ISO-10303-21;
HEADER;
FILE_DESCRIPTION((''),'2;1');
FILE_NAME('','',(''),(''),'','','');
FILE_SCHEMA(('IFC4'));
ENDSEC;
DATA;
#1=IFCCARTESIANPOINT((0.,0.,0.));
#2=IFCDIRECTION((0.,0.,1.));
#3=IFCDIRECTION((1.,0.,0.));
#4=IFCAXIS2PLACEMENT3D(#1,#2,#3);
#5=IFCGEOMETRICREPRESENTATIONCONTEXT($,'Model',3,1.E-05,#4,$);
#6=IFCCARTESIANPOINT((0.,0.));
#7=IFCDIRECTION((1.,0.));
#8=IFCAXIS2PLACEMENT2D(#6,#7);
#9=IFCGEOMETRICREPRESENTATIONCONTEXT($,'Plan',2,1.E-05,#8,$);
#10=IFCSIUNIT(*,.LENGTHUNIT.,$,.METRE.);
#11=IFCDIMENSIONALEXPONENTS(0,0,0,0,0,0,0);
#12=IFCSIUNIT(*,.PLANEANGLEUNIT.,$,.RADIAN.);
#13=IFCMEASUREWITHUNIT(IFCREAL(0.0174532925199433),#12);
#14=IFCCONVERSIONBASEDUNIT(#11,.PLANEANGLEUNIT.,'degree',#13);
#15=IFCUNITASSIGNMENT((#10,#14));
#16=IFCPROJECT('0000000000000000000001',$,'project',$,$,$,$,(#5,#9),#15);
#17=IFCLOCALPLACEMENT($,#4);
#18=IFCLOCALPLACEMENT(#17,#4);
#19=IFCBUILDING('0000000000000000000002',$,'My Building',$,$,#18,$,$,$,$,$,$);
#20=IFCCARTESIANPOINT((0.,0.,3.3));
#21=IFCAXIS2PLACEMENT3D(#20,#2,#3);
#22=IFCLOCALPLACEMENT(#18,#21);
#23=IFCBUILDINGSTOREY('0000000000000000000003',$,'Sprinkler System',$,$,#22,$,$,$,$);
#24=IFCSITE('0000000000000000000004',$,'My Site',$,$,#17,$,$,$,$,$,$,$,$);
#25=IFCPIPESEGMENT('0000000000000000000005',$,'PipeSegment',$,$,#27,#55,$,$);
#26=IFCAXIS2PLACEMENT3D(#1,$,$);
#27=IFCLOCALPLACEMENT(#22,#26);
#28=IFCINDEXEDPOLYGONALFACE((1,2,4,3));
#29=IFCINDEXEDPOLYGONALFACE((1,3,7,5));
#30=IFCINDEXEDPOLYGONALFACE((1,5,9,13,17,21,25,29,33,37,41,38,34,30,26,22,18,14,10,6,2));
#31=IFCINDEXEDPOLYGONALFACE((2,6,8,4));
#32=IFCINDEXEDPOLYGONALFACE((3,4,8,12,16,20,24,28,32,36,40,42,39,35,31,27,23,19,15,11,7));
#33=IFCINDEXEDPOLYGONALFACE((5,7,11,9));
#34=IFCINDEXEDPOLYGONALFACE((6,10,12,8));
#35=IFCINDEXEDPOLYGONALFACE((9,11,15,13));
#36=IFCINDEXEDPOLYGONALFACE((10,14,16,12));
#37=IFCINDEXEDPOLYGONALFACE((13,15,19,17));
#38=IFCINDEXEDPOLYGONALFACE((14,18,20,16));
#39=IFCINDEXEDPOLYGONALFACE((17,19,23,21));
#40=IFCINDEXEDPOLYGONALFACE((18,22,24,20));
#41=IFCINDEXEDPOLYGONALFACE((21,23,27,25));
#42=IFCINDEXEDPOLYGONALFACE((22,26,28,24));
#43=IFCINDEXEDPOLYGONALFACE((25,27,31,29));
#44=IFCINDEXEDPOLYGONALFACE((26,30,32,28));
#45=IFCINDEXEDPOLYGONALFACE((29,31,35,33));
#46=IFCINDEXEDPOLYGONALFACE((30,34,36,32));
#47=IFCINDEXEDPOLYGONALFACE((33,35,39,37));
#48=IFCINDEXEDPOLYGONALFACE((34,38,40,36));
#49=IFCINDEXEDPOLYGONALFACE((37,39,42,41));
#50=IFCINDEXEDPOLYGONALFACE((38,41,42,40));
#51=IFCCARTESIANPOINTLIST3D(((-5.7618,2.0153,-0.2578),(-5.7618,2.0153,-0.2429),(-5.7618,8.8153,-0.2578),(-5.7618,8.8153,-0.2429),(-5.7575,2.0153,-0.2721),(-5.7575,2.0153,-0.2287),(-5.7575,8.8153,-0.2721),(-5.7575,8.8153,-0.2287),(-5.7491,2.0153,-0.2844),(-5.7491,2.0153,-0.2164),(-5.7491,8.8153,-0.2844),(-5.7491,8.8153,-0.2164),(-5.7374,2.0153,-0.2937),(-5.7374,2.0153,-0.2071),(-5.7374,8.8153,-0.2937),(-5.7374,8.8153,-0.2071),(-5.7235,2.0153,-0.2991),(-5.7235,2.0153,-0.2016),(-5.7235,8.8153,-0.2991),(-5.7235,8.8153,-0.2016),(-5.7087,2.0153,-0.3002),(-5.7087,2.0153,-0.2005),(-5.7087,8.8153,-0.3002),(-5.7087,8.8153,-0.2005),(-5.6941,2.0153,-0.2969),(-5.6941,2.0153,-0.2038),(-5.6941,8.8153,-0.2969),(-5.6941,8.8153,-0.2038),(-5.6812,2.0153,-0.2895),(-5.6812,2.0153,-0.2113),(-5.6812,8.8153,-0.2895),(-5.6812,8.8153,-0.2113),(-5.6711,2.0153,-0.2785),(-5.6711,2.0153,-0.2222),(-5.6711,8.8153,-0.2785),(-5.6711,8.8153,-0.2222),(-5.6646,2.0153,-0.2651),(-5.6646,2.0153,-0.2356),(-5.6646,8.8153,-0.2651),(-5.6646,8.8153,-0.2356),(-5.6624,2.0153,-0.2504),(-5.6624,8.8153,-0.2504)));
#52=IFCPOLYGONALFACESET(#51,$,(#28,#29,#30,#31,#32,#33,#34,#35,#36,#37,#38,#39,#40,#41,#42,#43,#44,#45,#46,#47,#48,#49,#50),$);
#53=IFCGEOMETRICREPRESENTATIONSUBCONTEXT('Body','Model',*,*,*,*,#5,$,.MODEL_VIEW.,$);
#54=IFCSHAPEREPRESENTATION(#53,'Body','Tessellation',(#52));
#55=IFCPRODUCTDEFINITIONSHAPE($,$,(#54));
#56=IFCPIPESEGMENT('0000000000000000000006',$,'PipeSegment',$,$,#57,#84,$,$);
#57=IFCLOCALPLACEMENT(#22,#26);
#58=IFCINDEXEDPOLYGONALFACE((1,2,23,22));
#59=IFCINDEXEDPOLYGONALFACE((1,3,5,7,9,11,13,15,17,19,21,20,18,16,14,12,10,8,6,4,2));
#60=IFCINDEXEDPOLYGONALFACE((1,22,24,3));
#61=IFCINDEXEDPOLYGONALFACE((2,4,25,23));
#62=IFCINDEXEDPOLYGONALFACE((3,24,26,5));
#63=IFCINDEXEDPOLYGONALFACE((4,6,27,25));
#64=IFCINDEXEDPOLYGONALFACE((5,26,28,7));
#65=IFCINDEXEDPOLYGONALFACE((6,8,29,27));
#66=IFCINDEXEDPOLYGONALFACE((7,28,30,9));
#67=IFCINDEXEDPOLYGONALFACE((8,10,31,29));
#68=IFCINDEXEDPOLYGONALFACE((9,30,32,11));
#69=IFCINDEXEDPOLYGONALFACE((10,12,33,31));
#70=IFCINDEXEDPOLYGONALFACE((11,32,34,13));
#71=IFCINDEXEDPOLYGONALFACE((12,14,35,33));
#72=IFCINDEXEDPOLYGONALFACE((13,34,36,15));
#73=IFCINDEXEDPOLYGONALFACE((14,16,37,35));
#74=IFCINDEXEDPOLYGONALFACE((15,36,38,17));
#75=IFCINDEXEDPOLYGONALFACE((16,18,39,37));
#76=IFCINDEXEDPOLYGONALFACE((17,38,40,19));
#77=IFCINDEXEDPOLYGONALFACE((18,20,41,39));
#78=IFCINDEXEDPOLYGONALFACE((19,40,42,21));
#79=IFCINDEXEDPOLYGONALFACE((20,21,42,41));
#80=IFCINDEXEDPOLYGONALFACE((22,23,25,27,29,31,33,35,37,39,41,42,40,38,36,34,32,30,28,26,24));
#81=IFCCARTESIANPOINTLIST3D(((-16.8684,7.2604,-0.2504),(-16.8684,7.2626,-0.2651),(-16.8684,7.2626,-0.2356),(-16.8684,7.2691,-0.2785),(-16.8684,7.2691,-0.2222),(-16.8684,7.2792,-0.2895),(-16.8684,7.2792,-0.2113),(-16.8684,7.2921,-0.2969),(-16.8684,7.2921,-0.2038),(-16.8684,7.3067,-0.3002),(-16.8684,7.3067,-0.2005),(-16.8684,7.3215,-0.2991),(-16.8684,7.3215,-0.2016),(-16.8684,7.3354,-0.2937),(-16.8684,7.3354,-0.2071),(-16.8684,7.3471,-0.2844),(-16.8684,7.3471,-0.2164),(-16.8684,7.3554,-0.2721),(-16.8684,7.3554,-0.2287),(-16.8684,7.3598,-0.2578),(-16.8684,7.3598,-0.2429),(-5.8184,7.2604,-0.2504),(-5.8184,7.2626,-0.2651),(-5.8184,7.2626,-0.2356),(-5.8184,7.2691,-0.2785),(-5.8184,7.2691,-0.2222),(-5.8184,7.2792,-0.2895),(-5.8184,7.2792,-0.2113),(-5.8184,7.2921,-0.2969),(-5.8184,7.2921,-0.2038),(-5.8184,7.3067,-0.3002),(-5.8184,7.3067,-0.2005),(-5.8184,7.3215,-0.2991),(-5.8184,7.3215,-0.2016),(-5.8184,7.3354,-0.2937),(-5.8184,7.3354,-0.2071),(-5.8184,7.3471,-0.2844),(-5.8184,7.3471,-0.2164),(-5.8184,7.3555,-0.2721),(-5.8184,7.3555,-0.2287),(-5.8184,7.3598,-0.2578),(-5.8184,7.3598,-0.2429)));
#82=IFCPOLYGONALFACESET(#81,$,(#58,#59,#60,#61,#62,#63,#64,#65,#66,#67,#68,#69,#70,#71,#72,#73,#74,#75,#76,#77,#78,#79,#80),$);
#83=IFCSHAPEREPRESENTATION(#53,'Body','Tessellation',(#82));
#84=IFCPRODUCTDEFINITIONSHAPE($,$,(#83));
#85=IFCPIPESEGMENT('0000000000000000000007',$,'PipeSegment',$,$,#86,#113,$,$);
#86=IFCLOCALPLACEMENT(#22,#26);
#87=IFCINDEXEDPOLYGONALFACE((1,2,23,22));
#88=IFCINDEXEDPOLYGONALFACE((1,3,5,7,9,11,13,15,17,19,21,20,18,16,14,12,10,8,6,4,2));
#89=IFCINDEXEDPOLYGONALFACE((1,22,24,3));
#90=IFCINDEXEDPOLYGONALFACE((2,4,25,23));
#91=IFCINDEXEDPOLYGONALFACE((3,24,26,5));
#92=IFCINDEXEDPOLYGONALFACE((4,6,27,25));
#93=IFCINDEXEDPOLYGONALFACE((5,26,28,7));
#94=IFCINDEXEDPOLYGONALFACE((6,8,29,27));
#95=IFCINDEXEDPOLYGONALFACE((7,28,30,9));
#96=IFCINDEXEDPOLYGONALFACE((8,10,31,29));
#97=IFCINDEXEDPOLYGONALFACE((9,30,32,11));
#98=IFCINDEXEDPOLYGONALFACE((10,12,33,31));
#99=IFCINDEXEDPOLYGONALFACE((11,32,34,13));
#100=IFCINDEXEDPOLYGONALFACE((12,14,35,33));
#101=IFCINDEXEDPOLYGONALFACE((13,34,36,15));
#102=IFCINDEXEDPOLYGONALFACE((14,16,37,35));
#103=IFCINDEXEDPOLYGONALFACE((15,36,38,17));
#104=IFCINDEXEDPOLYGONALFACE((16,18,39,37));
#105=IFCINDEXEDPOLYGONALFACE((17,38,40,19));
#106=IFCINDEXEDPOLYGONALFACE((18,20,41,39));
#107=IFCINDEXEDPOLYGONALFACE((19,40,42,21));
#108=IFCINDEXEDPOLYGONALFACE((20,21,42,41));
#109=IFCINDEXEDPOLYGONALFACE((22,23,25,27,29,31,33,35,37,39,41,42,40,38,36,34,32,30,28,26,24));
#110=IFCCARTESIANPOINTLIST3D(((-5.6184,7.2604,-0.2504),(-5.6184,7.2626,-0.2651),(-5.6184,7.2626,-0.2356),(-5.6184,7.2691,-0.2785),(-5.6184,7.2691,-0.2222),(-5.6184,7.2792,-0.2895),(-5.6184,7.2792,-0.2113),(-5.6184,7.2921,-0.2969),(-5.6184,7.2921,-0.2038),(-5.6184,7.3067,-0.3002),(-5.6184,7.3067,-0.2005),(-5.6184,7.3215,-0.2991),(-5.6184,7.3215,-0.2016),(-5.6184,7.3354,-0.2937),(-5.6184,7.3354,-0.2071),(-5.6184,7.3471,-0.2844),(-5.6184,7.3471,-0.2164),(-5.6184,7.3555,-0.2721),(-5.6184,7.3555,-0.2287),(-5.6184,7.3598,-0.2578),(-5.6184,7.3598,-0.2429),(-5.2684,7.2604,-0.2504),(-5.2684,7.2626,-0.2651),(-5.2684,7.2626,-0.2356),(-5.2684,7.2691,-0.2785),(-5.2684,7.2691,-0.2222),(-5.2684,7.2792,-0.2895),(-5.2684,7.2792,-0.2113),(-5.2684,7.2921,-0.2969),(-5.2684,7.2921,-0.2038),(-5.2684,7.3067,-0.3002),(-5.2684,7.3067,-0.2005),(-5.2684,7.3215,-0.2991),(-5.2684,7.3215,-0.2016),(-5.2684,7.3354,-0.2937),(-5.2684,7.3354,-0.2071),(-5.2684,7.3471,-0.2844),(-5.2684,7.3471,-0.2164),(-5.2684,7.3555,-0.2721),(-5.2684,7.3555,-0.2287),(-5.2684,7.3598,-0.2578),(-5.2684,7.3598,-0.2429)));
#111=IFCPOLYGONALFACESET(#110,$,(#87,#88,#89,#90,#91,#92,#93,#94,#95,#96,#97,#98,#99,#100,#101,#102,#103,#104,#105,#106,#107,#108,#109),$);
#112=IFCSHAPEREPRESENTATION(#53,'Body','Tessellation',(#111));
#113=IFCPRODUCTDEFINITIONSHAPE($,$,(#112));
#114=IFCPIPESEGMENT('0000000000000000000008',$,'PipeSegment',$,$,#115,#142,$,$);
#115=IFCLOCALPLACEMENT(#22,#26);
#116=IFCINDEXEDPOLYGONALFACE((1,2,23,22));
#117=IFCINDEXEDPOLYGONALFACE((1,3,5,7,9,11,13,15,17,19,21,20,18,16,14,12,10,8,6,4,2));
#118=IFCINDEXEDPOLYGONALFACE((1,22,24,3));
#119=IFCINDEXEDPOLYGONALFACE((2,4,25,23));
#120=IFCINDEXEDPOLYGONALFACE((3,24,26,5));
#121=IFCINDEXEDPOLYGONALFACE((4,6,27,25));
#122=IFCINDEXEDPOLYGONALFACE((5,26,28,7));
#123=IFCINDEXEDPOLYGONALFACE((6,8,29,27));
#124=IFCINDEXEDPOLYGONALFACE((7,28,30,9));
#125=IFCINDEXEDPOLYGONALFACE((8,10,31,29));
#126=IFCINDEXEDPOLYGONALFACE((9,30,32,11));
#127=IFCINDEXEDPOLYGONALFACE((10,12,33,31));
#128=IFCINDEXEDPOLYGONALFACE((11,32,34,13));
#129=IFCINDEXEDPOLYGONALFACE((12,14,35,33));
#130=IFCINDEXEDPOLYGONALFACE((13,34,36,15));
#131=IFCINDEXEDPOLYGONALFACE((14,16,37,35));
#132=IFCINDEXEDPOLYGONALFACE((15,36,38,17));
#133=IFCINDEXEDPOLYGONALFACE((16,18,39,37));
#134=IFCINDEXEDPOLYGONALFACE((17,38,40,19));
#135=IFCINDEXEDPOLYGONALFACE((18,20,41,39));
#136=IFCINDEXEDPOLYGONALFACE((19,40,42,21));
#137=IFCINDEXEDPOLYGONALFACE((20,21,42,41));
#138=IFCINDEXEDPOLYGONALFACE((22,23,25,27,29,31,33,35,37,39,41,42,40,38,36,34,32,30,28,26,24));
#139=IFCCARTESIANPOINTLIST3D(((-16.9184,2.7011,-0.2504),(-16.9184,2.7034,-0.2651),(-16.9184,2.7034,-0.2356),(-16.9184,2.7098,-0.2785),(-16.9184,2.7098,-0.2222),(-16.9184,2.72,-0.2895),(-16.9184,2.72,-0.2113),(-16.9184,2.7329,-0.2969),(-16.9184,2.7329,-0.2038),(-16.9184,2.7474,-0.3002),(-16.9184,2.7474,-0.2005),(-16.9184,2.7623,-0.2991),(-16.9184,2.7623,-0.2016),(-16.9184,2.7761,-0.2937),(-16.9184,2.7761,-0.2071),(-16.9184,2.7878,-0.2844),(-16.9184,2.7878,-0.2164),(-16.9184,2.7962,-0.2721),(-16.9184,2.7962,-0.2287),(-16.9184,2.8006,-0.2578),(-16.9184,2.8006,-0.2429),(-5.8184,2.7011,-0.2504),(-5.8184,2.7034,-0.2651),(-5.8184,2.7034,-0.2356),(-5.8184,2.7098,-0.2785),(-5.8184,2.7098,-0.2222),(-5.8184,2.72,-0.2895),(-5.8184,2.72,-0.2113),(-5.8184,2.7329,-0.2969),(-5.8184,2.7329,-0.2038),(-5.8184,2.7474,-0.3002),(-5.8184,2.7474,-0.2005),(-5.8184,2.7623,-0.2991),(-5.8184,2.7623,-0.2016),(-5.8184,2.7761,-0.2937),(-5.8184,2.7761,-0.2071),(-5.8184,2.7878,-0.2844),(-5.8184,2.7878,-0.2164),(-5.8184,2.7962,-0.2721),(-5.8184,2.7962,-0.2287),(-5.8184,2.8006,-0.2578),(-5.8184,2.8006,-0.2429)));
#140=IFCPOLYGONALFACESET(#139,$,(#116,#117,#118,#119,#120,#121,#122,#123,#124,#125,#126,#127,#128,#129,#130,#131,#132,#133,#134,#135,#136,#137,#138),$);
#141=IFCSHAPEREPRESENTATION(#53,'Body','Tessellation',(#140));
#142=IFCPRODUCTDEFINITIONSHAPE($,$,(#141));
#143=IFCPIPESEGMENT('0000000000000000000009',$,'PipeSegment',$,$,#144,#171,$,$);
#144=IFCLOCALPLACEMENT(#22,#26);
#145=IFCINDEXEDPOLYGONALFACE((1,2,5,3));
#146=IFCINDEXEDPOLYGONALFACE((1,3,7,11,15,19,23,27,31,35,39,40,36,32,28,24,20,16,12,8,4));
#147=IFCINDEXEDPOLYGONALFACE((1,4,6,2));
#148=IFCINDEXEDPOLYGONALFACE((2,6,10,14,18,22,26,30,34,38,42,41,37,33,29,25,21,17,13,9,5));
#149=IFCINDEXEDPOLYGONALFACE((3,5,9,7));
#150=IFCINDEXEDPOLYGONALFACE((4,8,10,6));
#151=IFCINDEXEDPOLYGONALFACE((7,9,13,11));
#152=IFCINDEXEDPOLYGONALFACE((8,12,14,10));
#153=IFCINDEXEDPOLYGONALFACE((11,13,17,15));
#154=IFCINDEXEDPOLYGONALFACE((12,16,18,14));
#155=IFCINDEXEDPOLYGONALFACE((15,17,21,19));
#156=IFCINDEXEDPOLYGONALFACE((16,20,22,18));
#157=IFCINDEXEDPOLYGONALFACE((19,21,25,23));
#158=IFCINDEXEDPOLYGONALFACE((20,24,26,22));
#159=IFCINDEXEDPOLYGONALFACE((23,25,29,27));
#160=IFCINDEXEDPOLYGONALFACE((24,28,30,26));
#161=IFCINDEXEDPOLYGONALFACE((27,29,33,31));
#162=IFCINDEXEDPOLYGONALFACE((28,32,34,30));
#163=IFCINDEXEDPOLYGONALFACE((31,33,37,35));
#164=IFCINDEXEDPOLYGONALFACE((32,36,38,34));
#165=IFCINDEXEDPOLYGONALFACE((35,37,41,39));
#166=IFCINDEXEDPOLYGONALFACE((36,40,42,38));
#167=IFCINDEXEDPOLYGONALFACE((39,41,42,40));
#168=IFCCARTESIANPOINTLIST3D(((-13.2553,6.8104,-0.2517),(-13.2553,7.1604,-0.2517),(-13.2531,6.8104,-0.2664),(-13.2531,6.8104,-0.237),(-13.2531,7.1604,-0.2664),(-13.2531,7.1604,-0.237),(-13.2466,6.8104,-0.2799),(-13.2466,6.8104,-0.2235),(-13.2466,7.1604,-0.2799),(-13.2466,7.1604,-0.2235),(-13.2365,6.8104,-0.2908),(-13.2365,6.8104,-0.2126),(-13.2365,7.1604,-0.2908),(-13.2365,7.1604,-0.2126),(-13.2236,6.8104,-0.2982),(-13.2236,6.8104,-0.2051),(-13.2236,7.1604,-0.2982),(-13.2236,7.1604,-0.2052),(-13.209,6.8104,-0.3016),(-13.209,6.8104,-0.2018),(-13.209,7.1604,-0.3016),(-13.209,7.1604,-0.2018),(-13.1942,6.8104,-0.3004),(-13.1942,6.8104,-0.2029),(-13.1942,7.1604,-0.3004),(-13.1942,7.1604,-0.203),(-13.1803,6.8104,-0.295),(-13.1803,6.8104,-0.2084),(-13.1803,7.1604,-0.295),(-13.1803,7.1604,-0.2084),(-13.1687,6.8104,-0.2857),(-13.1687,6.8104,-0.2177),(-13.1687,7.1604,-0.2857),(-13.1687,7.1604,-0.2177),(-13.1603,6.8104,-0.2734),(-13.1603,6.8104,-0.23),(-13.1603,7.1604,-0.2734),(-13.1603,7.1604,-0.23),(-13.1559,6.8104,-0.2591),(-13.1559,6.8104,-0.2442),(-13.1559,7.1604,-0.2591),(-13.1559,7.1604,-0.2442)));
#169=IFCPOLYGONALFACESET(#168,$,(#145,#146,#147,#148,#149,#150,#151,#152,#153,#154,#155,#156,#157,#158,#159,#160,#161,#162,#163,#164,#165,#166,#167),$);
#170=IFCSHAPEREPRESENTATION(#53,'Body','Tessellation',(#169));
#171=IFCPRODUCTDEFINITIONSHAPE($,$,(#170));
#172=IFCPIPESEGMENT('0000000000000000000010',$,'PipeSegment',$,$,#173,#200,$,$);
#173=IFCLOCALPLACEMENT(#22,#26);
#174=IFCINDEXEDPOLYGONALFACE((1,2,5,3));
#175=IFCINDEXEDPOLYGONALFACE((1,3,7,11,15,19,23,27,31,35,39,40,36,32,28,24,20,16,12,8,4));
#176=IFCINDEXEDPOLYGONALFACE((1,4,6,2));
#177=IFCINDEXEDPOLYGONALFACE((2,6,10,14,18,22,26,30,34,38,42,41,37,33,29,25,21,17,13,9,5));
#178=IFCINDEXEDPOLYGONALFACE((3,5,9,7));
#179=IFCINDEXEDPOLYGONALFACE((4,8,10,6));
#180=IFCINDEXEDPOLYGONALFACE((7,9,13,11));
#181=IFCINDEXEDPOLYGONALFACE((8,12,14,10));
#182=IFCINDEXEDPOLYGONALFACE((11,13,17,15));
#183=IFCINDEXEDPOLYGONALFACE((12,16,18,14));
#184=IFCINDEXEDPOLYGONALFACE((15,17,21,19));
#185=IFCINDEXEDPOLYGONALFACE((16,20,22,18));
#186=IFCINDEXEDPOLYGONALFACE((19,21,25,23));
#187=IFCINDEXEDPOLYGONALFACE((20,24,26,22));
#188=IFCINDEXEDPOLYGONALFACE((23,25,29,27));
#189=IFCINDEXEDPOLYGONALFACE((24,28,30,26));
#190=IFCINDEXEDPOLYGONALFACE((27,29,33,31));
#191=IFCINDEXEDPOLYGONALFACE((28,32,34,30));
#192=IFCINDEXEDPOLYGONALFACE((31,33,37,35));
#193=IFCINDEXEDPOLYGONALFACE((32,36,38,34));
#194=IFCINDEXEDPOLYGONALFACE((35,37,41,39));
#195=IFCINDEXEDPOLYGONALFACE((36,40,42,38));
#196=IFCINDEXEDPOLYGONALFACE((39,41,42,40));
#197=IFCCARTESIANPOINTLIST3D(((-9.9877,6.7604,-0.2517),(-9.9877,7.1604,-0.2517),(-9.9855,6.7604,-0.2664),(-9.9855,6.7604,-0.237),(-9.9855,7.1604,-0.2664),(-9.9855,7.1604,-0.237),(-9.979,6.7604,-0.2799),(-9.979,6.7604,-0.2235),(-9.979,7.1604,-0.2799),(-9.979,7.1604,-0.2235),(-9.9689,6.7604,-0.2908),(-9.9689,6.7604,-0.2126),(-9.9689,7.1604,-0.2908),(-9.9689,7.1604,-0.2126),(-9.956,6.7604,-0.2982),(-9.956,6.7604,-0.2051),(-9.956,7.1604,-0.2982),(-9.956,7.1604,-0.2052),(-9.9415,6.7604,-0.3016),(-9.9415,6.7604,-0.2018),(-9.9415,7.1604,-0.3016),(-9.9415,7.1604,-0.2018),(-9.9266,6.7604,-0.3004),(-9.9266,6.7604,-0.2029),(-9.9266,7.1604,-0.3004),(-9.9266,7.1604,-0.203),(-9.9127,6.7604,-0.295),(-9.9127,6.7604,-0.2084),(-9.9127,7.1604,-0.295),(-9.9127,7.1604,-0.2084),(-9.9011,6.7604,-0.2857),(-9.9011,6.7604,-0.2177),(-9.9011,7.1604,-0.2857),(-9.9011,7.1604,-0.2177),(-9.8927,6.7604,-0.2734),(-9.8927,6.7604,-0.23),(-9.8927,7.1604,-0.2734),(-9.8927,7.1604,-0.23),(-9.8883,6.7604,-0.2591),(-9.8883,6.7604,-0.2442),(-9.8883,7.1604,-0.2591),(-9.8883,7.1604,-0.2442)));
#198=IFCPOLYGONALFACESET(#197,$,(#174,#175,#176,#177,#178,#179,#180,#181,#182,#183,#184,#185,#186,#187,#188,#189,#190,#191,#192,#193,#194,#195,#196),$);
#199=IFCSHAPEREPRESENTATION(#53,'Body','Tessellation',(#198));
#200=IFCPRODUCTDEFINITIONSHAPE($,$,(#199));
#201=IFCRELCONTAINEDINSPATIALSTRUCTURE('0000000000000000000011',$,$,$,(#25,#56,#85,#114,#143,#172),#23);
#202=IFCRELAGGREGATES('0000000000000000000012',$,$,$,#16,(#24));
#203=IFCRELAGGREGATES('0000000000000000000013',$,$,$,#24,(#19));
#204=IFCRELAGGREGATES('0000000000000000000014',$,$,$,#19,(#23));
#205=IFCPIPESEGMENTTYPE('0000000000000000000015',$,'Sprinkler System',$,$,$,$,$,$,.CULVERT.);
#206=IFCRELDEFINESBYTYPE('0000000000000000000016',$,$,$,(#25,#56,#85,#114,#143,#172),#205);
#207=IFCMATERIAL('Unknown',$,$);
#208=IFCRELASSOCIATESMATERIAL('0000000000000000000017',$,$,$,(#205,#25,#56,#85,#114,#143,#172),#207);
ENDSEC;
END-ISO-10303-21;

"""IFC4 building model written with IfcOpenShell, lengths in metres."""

from ifc_helpers import new_model, entity, si_unit, converted_unit, frame, origin_with_axes, origin_2d_with_axis, place, context, subcontext, project, spatial, circle, extrude, material, material_profile, profile_set, profile_usage, type_object, element, save


model = new_model("IFC4")

# Units and contexts
model_context = context("Model", 3, precision=1e-05, world=origin_with_axes())
plan_context = context("Plan", 2, precision=1e-05, world=origin_2d_with_axis())
body_context = subcontext(model_context, "Body", "Model", "MODEL_VIEW")
ifc_project = project(units=[si_unit("LENGTHUNIT", "METRE"), converted_unit("PLANEANGLEUNIT", "degree", entity("IfcReal", 0.0174532925199433), si_unit("PLANEANGLEUNIT", "RADIAN"), dimensions=[0, 0, 0, 0, 0, 0, 0])], contexts=[model_context, plan_context])

# Site, building, storey
site_placement = place(None, origin_with_axes())
site = spatial("IfcSite", under=ifc_project, at=site_placement, Name="My Site")
building_placement = place(site_placement, origin_with_axes())
building = spatial("IfcBuilding", under=site, at=building_placement, Name="My Building")
storey_placement = place(building_placement, frame((0.0, 0.0, 3.3), z_axis=(0.0, 0.0, 1.0), x_axis=(1.0, 0.0, 0.0)))
storey = spatial("IfcBuildingStorey", under=building, at=storey_placement, Name="Sprinkler System")

# Pipe segments
ifc_material = material(Name="Unknown")
ifc_material_profile_1 = material_profile(ifc_material, circle(Radius=0.05))
ifc_profile_set_1 = profile_set([ifc_material_profile_1])
ifc_profile_usage_1 = profile_usage(ifc_profile_set_1, cardinal=5)
pipe_segment_type = type_object("IfcPipeSegmentType", Name="Sprinkler System", PredefinedType="CULVERT", material=ifc_profile_set_1)
pipe_segment_1_placement = place(storey_placement, frame((-5.7124, 8.8153, -0.2504), z_axis=(0.0, -1.0, 0.0), x_axis=(1.0, 0.0, 0.0)))
element("IfcPipeSegment", 1, at=pipe_segment_1_placement, inside=storey, type_object=pipe_segment_type, material=ifc_profile_usage_1, Name="PipeSegment", context=body_context, shape_type="SweptSolid", body=[
    extrude(circle(Radius=0.05), origin_with_axes(), (0.0, 0.0, 1.0), 6.8),
])
ifc_profile_usage_2 = profile_usage(ifc_profile_set_1, cardinal=5)
pipe_segment_2_placement = place(storey_placement, frame((-5.8184, 7.3104, -0.2504), z_axis=(-1.0, 0.0, 0.0), x_axis=(0.0, -1.0, 0.0)))
element("IfcPipeSegment", 2, at=pipe_segment_2_placement, inside=storey, type_object=pipe_segment_type, material=ifc_profile_usage_2, Name="PipeSegment", context=body_context, shape_type="SweptSolid", body=[
    extrude(circle(Radius=0.05), origin_with_axes(), (0.0, 0.0, 1.0), 11.05),
])
ifc_profile_usage_3 = profile_usage(ifc_profile_set_1, cardinal=5)
pipe_segment_3_placement = place(storey_placement, frame((-5.2684, 7.3104, -0.2504), z_axis=(-1.0, 0.0, 0.0), x_axis=(0.0, -1.0, 0.0)))
element("IfcPipeSegment", 3, at=pipe_segment_3_placement, inside=storey, type_object=pipe_segment_type, material=ifc_profile_usage_3, Name="PipeSegment", context=body_context, shape_type="SweptSolid", body=[
    extrude(circle(Radius=0.05), origin_with_axes(), (0.0, 0.0, 1.0), 0.35),
])
ifc_profile_usage_4 = profile_usage(ifc_profile_set_1, cardinal=5)
pipe_segment_4_placement = place(storey_placement, frame((-5.8184, 2.7511, -0.2504), z_axis=(-1.0, 0.0, 0.0), x_axis=(0.0, -1.0, 0.0)))
element("IfcPipeSegment", 4, at=pipe_segment_4_placement, inside=storey, type_object=pipe_segment_type, material=ifc_profile_usage_4, Name="PipeSegment", context=body_context, shape_type="SweptSolid", body=[
    extrude(circle(Radius=0.05), origin_with_axes(), (0.0, 0.0, 1.0), 11.1),
])
ifc_profile_usage_5 = profile_usage(ifc_profile_set_1, cardinal=5)
pipe_segment_5_placement = place(storey_placement, frame((-13.2053, 6.8104, -0.2517), z_axis=(0.0, 1.0, -0.000012), x_axis=(-1.0, 0.0, 0.0)))
element("IfcPipeSegment", 5, at=pipe_segment_5_placement, inside=storey, type_object=pipe_segment_type, material=ifc_profile_usage_5, Name="PipeSegment", context=body_context, shape_type="SweptSolid", body=[
    extrude(circle(Radius=0.05), origin_with_axes(), (0.0, 0.0, 1.0), 0.35),
])
ifc_profile_usage_6 = profile_usage(ifc_profile_set_1, cardinal=5)
pipe_segment_6_placement = place(storey_placement, frame((-9.9377, 6.7604, -0.2517), z_axis=(0.0, 1.0, -0.000012), x_axis=(-1.0, 0.0, 0.0)))
element("IfcPipeSegment", 6, at=pipe_segment_6_placement, inside=storey, type_object=pipe_segment_type, material=ifc_profile_usage_6, Name="PipeSegment", context=body_context, shape_type="SweptSolid", body=[
    extrude(circle(Radius=0.05), origin_with_axes(), (0.0, 0.0, 1.0), 0.4),
])

save(model, "model.ifc")
